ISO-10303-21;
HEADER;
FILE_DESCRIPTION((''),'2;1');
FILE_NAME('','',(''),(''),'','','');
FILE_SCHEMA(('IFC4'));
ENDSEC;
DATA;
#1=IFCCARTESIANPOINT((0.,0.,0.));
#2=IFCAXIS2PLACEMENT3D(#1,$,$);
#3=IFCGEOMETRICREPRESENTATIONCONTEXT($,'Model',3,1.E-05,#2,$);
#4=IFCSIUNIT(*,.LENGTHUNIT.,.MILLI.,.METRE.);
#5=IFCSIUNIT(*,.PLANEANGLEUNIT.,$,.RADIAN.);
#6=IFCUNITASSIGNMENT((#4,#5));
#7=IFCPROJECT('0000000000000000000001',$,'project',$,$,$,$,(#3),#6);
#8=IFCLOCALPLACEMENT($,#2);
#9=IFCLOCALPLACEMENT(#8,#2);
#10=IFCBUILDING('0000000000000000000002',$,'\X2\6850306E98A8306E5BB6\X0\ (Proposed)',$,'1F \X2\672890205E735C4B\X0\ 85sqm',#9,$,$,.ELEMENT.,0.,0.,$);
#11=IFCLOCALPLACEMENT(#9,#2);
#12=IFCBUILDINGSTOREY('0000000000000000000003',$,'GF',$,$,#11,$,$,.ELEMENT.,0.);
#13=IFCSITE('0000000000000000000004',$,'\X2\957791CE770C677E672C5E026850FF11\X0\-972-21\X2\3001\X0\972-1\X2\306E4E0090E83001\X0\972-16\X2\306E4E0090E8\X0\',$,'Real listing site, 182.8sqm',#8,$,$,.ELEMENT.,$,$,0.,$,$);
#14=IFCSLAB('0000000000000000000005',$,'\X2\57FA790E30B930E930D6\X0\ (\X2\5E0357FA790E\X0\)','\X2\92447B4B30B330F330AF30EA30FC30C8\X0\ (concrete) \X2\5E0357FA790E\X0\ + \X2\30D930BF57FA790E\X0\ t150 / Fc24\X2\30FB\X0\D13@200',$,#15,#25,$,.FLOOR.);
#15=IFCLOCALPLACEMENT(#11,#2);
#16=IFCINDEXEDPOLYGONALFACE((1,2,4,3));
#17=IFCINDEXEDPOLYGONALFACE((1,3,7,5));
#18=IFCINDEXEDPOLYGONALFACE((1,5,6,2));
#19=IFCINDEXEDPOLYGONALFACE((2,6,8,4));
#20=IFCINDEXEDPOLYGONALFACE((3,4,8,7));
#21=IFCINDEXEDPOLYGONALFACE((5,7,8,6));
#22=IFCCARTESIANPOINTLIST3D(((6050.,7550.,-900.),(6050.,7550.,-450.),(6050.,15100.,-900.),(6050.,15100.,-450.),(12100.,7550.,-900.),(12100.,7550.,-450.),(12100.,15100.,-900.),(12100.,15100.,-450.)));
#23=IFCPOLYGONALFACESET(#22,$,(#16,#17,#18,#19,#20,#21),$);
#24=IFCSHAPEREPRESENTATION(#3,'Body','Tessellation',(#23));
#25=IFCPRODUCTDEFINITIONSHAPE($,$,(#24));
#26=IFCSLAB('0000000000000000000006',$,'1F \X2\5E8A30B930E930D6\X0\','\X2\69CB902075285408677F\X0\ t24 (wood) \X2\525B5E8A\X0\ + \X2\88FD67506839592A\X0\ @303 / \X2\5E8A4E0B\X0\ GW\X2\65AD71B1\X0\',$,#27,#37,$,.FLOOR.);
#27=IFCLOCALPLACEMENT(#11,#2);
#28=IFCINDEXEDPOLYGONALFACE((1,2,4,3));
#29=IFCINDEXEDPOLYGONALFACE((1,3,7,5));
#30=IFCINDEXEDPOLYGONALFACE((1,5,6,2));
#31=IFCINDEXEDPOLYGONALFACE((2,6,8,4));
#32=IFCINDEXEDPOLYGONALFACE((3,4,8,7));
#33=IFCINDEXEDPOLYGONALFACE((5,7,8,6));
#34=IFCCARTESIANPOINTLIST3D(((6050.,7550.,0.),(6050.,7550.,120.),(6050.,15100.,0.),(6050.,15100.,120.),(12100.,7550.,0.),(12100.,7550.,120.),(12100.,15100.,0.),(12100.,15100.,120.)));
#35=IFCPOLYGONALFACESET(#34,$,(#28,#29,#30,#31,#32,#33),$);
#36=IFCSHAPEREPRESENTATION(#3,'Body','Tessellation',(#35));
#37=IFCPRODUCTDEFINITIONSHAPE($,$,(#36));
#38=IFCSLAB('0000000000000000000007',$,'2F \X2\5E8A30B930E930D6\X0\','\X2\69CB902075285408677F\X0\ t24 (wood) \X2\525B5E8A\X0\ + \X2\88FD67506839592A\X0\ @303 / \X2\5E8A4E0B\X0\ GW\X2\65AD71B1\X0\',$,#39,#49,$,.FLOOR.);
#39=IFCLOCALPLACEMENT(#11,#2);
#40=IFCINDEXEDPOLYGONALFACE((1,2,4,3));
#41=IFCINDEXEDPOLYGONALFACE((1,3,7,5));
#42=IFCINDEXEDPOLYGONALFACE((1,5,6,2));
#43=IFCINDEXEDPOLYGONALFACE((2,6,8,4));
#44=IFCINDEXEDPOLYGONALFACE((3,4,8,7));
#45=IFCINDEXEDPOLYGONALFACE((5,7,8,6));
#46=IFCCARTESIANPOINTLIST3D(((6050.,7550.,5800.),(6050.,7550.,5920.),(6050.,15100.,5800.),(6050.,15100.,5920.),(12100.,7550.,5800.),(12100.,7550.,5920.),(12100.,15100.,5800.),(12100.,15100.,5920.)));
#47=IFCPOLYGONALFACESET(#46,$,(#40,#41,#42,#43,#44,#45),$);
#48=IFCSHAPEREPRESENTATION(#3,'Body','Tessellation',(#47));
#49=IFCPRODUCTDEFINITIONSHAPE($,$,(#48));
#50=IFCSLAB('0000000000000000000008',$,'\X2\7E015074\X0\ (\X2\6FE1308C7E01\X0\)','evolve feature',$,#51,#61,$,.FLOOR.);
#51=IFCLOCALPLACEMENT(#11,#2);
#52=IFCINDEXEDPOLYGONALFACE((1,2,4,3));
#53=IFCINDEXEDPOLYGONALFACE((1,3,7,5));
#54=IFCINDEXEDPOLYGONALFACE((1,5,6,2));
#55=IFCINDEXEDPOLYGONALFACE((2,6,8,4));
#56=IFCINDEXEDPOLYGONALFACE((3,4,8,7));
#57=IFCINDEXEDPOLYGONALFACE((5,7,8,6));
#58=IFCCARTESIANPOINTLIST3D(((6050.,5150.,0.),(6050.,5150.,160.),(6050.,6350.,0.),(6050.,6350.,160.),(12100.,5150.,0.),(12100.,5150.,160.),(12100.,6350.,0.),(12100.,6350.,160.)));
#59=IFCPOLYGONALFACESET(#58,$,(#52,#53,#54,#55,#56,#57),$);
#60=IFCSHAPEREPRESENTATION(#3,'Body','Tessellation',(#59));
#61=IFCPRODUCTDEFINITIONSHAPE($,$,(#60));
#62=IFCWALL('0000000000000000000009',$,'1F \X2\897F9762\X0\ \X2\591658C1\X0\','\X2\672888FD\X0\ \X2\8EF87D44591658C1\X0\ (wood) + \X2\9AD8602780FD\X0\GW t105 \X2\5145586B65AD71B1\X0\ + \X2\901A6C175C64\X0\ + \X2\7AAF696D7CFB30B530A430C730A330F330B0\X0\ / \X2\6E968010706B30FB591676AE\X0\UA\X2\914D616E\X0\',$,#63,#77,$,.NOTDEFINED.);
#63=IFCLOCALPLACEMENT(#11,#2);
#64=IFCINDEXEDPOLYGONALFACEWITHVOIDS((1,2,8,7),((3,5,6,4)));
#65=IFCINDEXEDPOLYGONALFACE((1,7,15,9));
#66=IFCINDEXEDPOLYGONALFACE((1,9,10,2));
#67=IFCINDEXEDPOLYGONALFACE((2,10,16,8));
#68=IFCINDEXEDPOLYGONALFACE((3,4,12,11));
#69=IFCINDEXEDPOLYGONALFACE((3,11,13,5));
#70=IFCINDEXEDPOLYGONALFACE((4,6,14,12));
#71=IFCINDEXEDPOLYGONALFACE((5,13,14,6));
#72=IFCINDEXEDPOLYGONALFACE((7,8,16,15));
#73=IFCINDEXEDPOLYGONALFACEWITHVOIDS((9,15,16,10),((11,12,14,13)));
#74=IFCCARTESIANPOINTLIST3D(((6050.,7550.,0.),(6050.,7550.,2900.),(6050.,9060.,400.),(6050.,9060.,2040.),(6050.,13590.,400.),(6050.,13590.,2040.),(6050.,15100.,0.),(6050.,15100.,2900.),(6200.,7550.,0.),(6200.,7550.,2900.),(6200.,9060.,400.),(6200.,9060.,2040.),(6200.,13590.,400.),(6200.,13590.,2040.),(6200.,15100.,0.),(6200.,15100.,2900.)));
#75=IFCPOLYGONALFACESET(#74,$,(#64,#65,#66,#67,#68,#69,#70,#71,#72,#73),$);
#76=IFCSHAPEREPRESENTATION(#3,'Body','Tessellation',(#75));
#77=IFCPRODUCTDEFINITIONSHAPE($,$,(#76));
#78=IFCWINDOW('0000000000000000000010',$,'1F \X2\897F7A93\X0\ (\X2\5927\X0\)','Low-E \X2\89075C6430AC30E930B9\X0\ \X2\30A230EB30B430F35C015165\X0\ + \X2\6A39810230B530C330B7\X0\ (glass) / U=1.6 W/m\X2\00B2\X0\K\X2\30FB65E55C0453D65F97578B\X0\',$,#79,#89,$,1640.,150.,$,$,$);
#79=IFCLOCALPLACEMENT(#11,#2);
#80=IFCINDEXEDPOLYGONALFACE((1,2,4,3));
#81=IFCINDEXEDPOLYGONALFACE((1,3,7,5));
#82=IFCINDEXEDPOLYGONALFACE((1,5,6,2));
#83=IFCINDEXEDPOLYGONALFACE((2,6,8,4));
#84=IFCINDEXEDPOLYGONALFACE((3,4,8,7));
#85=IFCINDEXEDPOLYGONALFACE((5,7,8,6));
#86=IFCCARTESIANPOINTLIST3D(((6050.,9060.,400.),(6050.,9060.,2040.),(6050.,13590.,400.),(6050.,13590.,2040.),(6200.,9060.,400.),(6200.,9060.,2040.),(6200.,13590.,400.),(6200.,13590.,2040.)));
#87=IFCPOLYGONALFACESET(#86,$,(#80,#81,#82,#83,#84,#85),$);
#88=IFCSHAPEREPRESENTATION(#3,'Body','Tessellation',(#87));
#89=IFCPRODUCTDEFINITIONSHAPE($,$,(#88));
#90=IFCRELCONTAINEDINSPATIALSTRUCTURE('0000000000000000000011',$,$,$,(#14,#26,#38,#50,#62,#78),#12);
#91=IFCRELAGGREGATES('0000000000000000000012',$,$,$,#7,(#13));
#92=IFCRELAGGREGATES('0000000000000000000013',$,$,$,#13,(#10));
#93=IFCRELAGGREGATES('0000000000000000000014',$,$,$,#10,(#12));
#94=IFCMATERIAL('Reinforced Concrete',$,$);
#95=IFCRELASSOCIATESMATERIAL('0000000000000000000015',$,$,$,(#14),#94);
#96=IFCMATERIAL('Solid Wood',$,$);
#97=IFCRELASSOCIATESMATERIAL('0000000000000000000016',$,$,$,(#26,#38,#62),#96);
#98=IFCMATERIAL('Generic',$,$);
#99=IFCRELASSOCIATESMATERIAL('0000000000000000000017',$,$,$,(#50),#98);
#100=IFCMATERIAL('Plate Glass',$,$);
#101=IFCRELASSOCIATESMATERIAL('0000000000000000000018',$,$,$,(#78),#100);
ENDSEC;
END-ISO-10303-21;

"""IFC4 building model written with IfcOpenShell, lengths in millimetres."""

from ifc_helpers import new_model, si_unit, frame, frame_2d, origin, place, context, project, spatial, rectangle, extrude, material, element, fill, save


model = new_model("IFC4")

# Units and contexts
model_context = context("Model", 3, precision=1e-05, world=origin())
ifc_project = project(units=[si_unit("LENGTHUNIT", "METRE", prefix="MILLI"), si_unit("PLANEANGLEUNIT", "RADIAN")], contexts=[model_context])

# Site, building, storey
site_placement = place(None, origin())
site = spatial("IfcSite", under=ifc_project, at=site_placement, Name="長野県松本市桐１-972-21、972-1の一部、972-16の一部", ObjectType="Real listing site, 182.8sqm", CompositionType="ELEMENT", RefElevation=0.0)
building_placement = place(site_placement, origin())
building = spatial("IfcBuilding", under=site, at=building_placement, Name="桐の風の家 (Proposed)", ObjectType="1F 木造平屋 85sqm", CompositionType="ELEMENT", ElevationOfRefHeight=0.0, ElevationOfTerrain=0.0)
storey_placement = place(building_placement, origin())
storey = spatial("IfcBuildingStorey", under=building, at=storey_placement, Name="GF", CompositionType="ELEMENT", Elevation=0.0)

# Slabs
ifc_material_1 = material(Name="Reinforced Concrete")
slab_1_placement = place(storey_placement, frame((3025.0, 3775.0, -450.0)))
element("IfcSlab", 1, at=slab_1_placement, inside=storey, material=ifc_material_1, Name="基礎スラブ (布基礎)", Description="鉄筋コンクリート (concrete) 布基礎 + ベタ基礎 t150 / Fc24・D13@200", PredefinedType="FLOOR", context=model_context, shape_type="SweptSolid", body=[
    extrude(rectangle(XDim=6050.0, YDim=7550.0, at=frame_2d((3025.0, 3775.0))), frame((3025.0, 3775.0, -450.0)), (0.0, 0.0, 1.0), 450.0),
])
ifc_material_2 = material(Name="Solid Wood")
slab_2_placement = place(storey_placement, frame((3025.0, 3775.0, 0.0)))
element("IfcSlab", 2, at=slab_2_placement, inside=storey, material=ifc_material_2, Name="1F 床スラブ", Description="構造用合板 t24 (wood) 剛床 + 製材根太 @303 / 床下 GW断熱", PredefinedType="FLOOR", context=model_context, shape_type="SweptSolid", body=[
    extrude(rectangle(XDim=6050.0, YDim=7550.0, at=frame_2d((3025.0, 3775.0))), frame((3025.0, 3775.0, 0.0)), (0.0, 0.0, 1.0), 120.0),
])
slab_3_placement = place(storey_placement, frame((3025.0, 3775.0, 2900.0)))
element("IfcSlab", 3, at=slab_3_placement, inside=storey, material=ifc_material_2, Name="2F 床スラブ", Description="構造用合板 t24 (wood) 剛床 + 製材根太 @303 / 床下 GW断熱", PredefinedType="FLOOR", context=model_context, shape_type="SweptSolid", body=[
    extrude(rectangle(XDim=6050.0, YDim=7550.0, at=frame_2d((3025.0, 3775.0))), frame((3025.0, 3775.0, 2900.0)), (0.0, 0.0, 1.0), 120.0),
])
ifc_material_3 = material(Name="Generic")
slab_4_placement = place(storey_placement, frame((3025.0, 2575.0, 0.0)))
element("IfcSlab", 4, at=slab_4_placement, inside=storey, material=ifc_material_3, Name="縁側 (濡れ縁)", Description="evolve feature", PredefinedType="FLOOR", context=model_context, shape_type="SweptSolid", body=[
    extrude(rectangle(XDim=6050.0, YDim=1200.0, at=frame_2d((3025.0, 600.0))), frame((3025.0, 2575.0, 0.0)), (0.0, 0.0, 1.0), 160.0),
])

# Shared definitions
ifc_material_4 = material(Name="Plate Glass")

# Wall, opening, window
wall_1_placement = place(storey_placement, frame((3025.0, 3775.0, 0.0)))
wall_1 = element("IfcWall", 5, at=wall_1_placement, inside=storey, material=ifc_material_2, Name="1F 西面 外壁", Description="木製 軸組外壁 (wood) + 高性能GW t105 充填断熱 + 通気層 + 窯業系サイディング / 準耐火・外皮UA配慮", PredefinedType="NOTDEFINED", context=model_context, shape_type="SweptSolid", body=[
    extrude(rectangle(XDim=150.0, YDim=7550.0, at=frame_2d((75.0, 3775.0))), frame((3025.0, 3775.0, 0.0)), (0.0, 0.0, 1.0), 2900.0),
])
opening_1_placement = place(storey_placement, frame((3025.0, 4530.0, 200.0)))
opening_1 = element("IfcOpeningElement", 6, at=opening_1_placement, cuts=wall_1, PredefinedType="NOTDEFINED", context=model_context, shape_type="SweptSolid", body=[
    extrude(rectangle(XDim=150.0, YDim=4530.0, at=frame_2d((75.0, 2265.0))), frame((3025.0, 4530.0, 200.0)), (0.0, 0.0, 1.0), 1640.0),
])
window_1_placement = place(storey_placement, frame((3025.0, 4530.0, 200.0)))
window_1 = element("IfcWindow", 7, at=window_1_placement, inside=storey, material=ifc_material_4, Name="1F 西窓 (大)", Description="Low-E 複層ガラス アルゴン封入 + 樹脂サッシ (glass) / U=1.6 W/m²K・日射取得型", OverallHeight=1640.0, OverallWidth=150.0, context=model_context, shape_type="SweptSolid", body=[
    extrude(rectangle(XDim=150.0, YDim=4530.0, at=frame_2d((75.0, 2265.0))), frame((3025.0, 4530.0, 200.0)), (0.0, 0.0, 1.0), 1640.0),
])
fill(opening_1, window_1)

save(model, "model.ifc")
